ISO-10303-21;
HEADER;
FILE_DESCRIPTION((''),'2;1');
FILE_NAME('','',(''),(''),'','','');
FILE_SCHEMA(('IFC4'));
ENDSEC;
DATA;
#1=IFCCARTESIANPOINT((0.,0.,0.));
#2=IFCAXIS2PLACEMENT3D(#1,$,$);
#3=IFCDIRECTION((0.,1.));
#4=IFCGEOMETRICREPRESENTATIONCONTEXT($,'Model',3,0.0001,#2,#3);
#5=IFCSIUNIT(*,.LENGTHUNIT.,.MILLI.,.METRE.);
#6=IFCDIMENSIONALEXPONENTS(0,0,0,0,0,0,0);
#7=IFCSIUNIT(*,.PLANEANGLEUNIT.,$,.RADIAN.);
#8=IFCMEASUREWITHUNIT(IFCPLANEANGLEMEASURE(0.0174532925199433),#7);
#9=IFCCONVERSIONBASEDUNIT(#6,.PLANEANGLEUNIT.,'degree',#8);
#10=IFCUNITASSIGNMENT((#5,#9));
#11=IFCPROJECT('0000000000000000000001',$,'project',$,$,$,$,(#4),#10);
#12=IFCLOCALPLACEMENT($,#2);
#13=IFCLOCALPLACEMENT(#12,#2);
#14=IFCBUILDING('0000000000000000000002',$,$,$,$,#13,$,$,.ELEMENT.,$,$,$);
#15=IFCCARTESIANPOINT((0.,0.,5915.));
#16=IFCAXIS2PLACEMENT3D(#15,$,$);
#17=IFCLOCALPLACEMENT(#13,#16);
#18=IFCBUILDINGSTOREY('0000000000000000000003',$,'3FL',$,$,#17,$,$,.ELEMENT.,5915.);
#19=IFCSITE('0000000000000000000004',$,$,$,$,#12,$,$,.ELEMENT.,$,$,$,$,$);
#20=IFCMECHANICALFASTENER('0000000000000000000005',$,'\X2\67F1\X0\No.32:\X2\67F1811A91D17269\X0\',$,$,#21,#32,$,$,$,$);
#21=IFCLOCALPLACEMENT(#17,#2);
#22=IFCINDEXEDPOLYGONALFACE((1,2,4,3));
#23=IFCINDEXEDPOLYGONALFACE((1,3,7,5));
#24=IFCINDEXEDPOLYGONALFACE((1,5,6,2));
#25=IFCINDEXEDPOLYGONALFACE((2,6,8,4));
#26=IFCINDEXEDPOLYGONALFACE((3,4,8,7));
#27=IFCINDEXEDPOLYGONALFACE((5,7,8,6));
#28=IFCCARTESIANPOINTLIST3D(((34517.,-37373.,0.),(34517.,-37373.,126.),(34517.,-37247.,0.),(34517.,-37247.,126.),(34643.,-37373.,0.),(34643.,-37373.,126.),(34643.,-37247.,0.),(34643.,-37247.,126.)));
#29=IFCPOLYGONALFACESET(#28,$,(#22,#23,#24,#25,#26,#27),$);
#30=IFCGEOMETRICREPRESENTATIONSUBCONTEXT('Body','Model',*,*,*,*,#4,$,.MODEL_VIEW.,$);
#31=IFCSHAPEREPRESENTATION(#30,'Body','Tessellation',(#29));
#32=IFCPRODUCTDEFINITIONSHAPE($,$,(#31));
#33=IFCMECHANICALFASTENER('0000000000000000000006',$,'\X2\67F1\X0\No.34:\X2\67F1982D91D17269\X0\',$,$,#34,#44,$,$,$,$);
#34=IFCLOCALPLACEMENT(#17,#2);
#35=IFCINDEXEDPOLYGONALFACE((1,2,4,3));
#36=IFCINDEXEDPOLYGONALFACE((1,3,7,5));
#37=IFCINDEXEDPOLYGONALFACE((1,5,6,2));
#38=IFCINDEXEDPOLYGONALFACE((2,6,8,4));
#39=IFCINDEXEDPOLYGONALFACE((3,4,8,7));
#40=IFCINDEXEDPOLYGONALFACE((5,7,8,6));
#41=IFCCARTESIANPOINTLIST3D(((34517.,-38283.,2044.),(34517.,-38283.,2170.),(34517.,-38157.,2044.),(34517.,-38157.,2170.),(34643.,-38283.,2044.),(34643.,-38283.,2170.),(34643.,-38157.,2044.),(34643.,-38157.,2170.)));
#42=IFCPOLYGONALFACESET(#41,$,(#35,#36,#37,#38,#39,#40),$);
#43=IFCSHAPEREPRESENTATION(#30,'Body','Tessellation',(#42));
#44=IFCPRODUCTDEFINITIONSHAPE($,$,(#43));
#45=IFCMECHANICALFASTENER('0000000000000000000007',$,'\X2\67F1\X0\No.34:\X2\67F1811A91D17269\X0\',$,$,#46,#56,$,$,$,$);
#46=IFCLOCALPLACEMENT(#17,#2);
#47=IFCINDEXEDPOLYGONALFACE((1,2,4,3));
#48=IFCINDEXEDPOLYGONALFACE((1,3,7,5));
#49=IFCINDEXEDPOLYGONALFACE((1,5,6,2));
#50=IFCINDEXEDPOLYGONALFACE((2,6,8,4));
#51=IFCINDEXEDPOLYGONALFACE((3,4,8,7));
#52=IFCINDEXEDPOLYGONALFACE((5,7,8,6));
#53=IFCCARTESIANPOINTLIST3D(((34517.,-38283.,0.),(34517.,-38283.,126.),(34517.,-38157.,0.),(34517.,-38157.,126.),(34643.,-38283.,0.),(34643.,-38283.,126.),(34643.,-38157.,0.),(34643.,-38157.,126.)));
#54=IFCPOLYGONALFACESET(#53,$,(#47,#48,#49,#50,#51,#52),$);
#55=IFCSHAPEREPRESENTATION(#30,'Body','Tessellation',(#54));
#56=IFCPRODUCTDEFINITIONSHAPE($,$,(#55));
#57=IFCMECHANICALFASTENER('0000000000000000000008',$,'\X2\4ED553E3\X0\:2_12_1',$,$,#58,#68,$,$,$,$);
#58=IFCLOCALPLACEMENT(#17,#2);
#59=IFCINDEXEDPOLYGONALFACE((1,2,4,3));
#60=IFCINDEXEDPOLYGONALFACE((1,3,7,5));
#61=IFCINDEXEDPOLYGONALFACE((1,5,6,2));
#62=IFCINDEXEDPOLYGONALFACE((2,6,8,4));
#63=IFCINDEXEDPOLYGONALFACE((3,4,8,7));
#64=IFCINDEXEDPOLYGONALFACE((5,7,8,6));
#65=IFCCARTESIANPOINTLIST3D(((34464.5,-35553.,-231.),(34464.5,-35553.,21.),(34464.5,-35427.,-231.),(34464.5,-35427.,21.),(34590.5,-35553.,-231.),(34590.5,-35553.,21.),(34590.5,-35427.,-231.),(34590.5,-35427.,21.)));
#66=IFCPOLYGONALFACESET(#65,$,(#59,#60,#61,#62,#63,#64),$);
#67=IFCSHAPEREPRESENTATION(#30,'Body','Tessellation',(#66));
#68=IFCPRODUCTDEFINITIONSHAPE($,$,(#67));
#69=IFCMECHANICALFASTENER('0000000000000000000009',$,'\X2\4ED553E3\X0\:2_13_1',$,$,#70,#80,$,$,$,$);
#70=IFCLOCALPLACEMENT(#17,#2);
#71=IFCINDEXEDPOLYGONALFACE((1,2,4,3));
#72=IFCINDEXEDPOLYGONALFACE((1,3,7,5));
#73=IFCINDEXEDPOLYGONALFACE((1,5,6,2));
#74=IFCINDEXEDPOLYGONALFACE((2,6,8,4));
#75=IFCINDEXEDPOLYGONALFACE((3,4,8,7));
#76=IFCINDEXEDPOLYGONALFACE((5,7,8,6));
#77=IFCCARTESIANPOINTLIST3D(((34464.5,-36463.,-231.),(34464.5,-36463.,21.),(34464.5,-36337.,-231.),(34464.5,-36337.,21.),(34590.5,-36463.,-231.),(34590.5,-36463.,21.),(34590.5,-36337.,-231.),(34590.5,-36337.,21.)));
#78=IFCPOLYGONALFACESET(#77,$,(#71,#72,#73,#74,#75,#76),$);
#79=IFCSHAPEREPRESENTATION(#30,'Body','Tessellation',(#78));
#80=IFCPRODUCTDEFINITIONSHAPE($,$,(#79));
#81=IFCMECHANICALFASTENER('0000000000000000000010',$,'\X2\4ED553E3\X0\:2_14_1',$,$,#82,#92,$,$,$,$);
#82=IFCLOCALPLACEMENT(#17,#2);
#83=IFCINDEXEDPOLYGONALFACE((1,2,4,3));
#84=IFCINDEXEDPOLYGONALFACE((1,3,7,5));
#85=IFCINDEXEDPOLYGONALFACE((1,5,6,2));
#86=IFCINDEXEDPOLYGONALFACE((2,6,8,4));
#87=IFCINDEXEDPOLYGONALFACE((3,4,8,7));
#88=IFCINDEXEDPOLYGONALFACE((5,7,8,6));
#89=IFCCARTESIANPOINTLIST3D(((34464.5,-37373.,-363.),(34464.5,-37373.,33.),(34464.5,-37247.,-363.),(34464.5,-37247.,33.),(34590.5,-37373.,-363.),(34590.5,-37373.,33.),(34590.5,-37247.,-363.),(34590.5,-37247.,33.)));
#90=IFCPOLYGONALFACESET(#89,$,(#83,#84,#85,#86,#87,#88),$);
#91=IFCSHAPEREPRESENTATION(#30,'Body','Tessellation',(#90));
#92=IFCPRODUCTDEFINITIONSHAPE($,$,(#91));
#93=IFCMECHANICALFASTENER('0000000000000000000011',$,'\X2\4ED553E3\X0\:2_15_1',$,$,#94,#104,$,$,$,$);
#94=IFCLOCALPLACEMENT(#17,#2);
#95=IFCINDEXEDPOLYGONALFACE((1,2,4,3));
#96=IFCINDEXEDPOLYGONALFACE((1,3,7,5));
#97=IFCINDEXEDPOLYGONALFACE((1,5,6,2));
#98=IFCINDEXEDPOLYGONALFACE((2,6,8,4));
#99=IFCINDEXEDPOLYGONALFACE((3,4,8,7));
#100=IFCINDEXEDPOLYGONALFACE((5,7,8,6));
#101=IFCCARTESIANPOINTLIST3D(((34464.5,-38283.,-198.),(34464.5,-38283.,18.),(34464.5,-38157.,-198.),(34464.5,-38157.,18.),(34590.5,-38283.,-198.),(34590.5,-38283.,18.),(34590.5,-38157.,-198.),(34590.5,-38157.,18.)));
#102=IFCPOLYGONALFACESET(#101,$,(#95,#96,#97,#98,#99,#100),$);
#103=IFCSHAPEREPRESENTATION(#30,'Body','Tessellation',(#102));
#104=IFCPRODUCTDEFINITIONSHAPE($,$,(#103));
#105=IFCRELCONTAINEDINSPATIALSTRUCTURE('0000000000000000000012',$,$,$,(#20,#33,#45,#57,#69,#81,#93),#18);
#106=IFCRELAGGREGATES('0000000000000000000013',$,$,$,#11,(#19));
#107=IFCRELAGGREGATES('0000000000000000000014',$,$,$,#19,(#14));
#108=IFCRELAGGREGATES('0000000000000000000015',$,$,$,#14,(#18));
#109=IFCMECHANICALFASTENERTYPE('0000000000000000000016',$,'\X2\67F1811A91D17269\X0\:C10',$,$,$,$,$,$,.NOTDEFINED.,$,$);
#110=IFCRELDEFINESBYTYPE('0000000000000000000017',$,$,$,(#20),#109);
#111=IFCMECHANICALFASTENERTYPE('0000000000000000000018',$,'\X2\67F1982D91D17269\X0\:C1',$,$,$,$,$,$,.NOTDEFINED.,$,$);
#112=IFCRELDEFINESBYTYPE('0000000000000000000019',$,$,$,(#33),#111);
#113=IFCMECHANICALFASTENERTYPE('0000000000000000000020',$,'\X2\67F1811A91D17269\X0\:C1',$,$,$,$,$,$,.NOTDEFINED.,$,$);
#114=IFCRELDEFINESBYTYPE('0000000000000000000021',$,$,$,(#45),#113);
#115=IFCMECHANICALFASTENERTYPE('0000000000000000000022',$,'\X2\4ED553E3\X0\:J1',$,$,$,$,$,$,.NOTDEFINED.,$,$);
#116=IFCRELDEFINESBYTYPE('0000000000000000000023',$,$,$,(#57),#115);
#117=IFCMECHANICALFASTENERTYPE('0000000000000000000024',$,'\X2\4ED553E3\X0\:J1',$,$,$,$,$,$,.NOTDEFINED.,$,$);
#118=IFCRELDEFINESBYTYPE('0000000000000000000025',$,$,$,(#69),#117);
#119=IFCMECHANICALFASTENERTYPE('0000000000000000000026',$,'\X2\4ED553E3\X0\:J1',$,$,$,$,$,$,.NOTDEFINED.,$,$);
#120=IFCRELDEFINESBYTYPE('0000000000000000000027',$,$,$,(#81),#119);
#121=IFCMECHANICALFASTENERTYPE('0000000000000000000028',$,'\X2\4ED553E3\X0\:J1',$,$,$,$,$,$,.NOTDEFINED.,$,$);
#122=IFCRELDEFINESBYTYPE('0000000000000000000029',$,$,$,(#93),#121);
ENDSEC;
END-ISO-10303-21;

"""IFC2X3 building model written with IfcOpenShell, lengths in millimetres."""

from ifc_helpers import new_model, entity, si_unit, converted_unit, direction, frame, origin, origin_with_axes, origin_2d, place, context, subcontext, project, spatial, rectangle, extrude, type_object, element, save


model = new_model("IFC2X3")

# Units and contexts
model_context = context("Model", 3, precision=0.0001, world=origin(), true_north=direction((0.0, 1.0)))
body_context = subcontext(model_context, "Body", "Model", "MODEL_VIEW")
ifc_project = project(units=[si_unit("LENGTHUNIT", "METRE", prefix="MILLI"), converted_unit("PLANEANGLEUNIT", "degree", entity("IfcPlaneAngleMeasure", 0.0174532925199433), si_unit("PLANEANGLEUNIT", "RADIAN"), dimensions=[0, 0, 0, 0, 0, 0, 0])], contexts=[model_context])

# Site, building, storey
site_placement = place(None, origin())
site = spatial("IfcSite", under=ifc_project, at=site_placement, CompositionType="ELEMENT")
building_placement = place(site_placement, origin())
building = spatial("IfcBuilding", under=site, at=building_placement, CompositionType="ELEMENT")
storey_placement = place(building_placement, frame((0.0, 0.0, 5915.0)))
storey = spatial("IfcBuildingStorey", under=building, at=storey_placement, Name="3FL", CompositionType="ELEMENT", Elevation=5915.0)

# Mechanical fasteners
mechanical_fastener_type_1 = type_object("IfcMechanicalFastenerType", Name="柱脚金物:C10")
mechanical_fastener_1_placement = place(storey_placement, frame((34580.0, -37310.0, 0.0)))
element("IfcMechanicalFastener", 1, at=mechanical_fastener_1_placement, inside=storey, type_object=mechanical_fastener_type_1, Name="柱No.32:柱脚金物", context=body_context, shape_type="SweptSolid", body=[
    extrude(rectangle(XDim=126.0, YDim=126.0, at=origin_2d()), origin_with_axes(), (0.0, 0.0, 1.0), 126.0),
])
mechanical_fastener_type_2 = type_object("IfcMechanicalFastenerType", Name="柱頭金物:C1")
mechanical_fastener_2_placement = place(storey_placement, frame((34580.0, -38220.0, 2044.0)))
element("IfcMechanicalFastener", 2, at=mechanical_fastener_2_placement, inside=storey, type_object=mechanical_fastener_type_2, Name="柱No.34:柱頭金物", context=body_context, shape_type="SweptSolid", body=[
    extrude(rectangle(XDim=126.0, YDim=126.0, at=origin_2d()), origin_with_axes(), (0.0, 0.0, 1.0), 126.0),
])
mechanical_fastener_type_3 = type_object("IfcMechanicalFastenerType", Name="柱脚金物:C1")
mechanical_fastener_3_placement = place(storey_placement, frame((34580.0, -38220.0, 0.0)))
element("IfcMechanicalFastener", 3, at=mechanical_fastener_3_placement, inside=storey, type_object=mechanical_fastener_type_3, Name="柱No.34:柱脚金物", context=body_context, shape_type="SweptSolid", body=[
    extrude(rectangle(XDim=126.0, YDim=126.0, at=origin_2d()), origin_with_axes(), (0.0, 0.0, 1.0), 126.0),
])
mechanical_fastener_type_4 = type_object("IfcMechanicalFastenerType", Name="仕口:J1")
mechanical_fastener_4_placement = place(storey_placement, frame((34527.5, -35490.0, -231.0)))
element("IfcMechanicalFastener", 4, at=mechanical_fastener_4_placement, inside=storey, type_object=mechanical_fastener_type_4, Name="仕口:2_12_1", context=body_context, shape_type="SweptSolid", body=[
    extrude(rectangle(XDim=126.0, YDim=126.0, at=origin_2d()), origin_with_axes(), (0.0, 0.0, 1.0), 252.0),
])
mechanical_fastener_type_5 = type_object("IfcMechanicalFastenerType", Name="仕口:J1")
mechanical_fastener_5_placement = place(storey_placement, frame((34527.5, -36400.0, -231.0)))
element("IfcMechanicalFastener", 5, at=mechanical_fastener_5_placement, inside=storey, type_object=mechanical_fastener_type_5, Name="仕口:2_13_1", context=body_context, shape_type="SweptSolid", body=[
    extrude(rectangle(XDim=126.0, YDim=126.0, at=origin_2d()), origin_with_axes(), (0.0, 0.0, 1.0), 252.0),
])
mechanical_fastener_type_6 = type_object("IfcMechanicalFastenerType", Name="仕口:J1")
mechanical_fastener_6_placement = place(storey_placement, frame((34527.5, -37310.0, -363.0)))
element("IfcMechanicalFastener", 6, at=mechanical_fastener_6_placement, inside=storey, type_object=mechanical_fastener_type_6, Name="仕口:2_14_1", context=body_context, shape_type="SweptSolid", body=[
    extrude(rectangle(XDim=126.0, YDim=126.0, at=origin_2d()), origin_with_axes(), (0.0, 0.0, 1.0), 396.0),
])
mechanical_fastener_type_7 = type_object("IfcMechanicalFastenerType", Name="仕口:J1")
mechanical_fastener_7_placement = place(storey_placement, frame((34527.5, -38220.0, -198.0)))
element("IfcMechanicalFastener", 7, at=mechanical_fastener_7_placement, inside=storey, type_object=mechanical_fastener_type_7, Name="仕口:2_15_1", context=body_context, shape_type="SweptSolid", body=[
    extrude(rectangle(XDim=126.0, YDim=126.0, at=origin_2d()), origin_with_axes(), (0.0, 0.0, 1.0), 216.0),
])

save(model, "model.ifc")
